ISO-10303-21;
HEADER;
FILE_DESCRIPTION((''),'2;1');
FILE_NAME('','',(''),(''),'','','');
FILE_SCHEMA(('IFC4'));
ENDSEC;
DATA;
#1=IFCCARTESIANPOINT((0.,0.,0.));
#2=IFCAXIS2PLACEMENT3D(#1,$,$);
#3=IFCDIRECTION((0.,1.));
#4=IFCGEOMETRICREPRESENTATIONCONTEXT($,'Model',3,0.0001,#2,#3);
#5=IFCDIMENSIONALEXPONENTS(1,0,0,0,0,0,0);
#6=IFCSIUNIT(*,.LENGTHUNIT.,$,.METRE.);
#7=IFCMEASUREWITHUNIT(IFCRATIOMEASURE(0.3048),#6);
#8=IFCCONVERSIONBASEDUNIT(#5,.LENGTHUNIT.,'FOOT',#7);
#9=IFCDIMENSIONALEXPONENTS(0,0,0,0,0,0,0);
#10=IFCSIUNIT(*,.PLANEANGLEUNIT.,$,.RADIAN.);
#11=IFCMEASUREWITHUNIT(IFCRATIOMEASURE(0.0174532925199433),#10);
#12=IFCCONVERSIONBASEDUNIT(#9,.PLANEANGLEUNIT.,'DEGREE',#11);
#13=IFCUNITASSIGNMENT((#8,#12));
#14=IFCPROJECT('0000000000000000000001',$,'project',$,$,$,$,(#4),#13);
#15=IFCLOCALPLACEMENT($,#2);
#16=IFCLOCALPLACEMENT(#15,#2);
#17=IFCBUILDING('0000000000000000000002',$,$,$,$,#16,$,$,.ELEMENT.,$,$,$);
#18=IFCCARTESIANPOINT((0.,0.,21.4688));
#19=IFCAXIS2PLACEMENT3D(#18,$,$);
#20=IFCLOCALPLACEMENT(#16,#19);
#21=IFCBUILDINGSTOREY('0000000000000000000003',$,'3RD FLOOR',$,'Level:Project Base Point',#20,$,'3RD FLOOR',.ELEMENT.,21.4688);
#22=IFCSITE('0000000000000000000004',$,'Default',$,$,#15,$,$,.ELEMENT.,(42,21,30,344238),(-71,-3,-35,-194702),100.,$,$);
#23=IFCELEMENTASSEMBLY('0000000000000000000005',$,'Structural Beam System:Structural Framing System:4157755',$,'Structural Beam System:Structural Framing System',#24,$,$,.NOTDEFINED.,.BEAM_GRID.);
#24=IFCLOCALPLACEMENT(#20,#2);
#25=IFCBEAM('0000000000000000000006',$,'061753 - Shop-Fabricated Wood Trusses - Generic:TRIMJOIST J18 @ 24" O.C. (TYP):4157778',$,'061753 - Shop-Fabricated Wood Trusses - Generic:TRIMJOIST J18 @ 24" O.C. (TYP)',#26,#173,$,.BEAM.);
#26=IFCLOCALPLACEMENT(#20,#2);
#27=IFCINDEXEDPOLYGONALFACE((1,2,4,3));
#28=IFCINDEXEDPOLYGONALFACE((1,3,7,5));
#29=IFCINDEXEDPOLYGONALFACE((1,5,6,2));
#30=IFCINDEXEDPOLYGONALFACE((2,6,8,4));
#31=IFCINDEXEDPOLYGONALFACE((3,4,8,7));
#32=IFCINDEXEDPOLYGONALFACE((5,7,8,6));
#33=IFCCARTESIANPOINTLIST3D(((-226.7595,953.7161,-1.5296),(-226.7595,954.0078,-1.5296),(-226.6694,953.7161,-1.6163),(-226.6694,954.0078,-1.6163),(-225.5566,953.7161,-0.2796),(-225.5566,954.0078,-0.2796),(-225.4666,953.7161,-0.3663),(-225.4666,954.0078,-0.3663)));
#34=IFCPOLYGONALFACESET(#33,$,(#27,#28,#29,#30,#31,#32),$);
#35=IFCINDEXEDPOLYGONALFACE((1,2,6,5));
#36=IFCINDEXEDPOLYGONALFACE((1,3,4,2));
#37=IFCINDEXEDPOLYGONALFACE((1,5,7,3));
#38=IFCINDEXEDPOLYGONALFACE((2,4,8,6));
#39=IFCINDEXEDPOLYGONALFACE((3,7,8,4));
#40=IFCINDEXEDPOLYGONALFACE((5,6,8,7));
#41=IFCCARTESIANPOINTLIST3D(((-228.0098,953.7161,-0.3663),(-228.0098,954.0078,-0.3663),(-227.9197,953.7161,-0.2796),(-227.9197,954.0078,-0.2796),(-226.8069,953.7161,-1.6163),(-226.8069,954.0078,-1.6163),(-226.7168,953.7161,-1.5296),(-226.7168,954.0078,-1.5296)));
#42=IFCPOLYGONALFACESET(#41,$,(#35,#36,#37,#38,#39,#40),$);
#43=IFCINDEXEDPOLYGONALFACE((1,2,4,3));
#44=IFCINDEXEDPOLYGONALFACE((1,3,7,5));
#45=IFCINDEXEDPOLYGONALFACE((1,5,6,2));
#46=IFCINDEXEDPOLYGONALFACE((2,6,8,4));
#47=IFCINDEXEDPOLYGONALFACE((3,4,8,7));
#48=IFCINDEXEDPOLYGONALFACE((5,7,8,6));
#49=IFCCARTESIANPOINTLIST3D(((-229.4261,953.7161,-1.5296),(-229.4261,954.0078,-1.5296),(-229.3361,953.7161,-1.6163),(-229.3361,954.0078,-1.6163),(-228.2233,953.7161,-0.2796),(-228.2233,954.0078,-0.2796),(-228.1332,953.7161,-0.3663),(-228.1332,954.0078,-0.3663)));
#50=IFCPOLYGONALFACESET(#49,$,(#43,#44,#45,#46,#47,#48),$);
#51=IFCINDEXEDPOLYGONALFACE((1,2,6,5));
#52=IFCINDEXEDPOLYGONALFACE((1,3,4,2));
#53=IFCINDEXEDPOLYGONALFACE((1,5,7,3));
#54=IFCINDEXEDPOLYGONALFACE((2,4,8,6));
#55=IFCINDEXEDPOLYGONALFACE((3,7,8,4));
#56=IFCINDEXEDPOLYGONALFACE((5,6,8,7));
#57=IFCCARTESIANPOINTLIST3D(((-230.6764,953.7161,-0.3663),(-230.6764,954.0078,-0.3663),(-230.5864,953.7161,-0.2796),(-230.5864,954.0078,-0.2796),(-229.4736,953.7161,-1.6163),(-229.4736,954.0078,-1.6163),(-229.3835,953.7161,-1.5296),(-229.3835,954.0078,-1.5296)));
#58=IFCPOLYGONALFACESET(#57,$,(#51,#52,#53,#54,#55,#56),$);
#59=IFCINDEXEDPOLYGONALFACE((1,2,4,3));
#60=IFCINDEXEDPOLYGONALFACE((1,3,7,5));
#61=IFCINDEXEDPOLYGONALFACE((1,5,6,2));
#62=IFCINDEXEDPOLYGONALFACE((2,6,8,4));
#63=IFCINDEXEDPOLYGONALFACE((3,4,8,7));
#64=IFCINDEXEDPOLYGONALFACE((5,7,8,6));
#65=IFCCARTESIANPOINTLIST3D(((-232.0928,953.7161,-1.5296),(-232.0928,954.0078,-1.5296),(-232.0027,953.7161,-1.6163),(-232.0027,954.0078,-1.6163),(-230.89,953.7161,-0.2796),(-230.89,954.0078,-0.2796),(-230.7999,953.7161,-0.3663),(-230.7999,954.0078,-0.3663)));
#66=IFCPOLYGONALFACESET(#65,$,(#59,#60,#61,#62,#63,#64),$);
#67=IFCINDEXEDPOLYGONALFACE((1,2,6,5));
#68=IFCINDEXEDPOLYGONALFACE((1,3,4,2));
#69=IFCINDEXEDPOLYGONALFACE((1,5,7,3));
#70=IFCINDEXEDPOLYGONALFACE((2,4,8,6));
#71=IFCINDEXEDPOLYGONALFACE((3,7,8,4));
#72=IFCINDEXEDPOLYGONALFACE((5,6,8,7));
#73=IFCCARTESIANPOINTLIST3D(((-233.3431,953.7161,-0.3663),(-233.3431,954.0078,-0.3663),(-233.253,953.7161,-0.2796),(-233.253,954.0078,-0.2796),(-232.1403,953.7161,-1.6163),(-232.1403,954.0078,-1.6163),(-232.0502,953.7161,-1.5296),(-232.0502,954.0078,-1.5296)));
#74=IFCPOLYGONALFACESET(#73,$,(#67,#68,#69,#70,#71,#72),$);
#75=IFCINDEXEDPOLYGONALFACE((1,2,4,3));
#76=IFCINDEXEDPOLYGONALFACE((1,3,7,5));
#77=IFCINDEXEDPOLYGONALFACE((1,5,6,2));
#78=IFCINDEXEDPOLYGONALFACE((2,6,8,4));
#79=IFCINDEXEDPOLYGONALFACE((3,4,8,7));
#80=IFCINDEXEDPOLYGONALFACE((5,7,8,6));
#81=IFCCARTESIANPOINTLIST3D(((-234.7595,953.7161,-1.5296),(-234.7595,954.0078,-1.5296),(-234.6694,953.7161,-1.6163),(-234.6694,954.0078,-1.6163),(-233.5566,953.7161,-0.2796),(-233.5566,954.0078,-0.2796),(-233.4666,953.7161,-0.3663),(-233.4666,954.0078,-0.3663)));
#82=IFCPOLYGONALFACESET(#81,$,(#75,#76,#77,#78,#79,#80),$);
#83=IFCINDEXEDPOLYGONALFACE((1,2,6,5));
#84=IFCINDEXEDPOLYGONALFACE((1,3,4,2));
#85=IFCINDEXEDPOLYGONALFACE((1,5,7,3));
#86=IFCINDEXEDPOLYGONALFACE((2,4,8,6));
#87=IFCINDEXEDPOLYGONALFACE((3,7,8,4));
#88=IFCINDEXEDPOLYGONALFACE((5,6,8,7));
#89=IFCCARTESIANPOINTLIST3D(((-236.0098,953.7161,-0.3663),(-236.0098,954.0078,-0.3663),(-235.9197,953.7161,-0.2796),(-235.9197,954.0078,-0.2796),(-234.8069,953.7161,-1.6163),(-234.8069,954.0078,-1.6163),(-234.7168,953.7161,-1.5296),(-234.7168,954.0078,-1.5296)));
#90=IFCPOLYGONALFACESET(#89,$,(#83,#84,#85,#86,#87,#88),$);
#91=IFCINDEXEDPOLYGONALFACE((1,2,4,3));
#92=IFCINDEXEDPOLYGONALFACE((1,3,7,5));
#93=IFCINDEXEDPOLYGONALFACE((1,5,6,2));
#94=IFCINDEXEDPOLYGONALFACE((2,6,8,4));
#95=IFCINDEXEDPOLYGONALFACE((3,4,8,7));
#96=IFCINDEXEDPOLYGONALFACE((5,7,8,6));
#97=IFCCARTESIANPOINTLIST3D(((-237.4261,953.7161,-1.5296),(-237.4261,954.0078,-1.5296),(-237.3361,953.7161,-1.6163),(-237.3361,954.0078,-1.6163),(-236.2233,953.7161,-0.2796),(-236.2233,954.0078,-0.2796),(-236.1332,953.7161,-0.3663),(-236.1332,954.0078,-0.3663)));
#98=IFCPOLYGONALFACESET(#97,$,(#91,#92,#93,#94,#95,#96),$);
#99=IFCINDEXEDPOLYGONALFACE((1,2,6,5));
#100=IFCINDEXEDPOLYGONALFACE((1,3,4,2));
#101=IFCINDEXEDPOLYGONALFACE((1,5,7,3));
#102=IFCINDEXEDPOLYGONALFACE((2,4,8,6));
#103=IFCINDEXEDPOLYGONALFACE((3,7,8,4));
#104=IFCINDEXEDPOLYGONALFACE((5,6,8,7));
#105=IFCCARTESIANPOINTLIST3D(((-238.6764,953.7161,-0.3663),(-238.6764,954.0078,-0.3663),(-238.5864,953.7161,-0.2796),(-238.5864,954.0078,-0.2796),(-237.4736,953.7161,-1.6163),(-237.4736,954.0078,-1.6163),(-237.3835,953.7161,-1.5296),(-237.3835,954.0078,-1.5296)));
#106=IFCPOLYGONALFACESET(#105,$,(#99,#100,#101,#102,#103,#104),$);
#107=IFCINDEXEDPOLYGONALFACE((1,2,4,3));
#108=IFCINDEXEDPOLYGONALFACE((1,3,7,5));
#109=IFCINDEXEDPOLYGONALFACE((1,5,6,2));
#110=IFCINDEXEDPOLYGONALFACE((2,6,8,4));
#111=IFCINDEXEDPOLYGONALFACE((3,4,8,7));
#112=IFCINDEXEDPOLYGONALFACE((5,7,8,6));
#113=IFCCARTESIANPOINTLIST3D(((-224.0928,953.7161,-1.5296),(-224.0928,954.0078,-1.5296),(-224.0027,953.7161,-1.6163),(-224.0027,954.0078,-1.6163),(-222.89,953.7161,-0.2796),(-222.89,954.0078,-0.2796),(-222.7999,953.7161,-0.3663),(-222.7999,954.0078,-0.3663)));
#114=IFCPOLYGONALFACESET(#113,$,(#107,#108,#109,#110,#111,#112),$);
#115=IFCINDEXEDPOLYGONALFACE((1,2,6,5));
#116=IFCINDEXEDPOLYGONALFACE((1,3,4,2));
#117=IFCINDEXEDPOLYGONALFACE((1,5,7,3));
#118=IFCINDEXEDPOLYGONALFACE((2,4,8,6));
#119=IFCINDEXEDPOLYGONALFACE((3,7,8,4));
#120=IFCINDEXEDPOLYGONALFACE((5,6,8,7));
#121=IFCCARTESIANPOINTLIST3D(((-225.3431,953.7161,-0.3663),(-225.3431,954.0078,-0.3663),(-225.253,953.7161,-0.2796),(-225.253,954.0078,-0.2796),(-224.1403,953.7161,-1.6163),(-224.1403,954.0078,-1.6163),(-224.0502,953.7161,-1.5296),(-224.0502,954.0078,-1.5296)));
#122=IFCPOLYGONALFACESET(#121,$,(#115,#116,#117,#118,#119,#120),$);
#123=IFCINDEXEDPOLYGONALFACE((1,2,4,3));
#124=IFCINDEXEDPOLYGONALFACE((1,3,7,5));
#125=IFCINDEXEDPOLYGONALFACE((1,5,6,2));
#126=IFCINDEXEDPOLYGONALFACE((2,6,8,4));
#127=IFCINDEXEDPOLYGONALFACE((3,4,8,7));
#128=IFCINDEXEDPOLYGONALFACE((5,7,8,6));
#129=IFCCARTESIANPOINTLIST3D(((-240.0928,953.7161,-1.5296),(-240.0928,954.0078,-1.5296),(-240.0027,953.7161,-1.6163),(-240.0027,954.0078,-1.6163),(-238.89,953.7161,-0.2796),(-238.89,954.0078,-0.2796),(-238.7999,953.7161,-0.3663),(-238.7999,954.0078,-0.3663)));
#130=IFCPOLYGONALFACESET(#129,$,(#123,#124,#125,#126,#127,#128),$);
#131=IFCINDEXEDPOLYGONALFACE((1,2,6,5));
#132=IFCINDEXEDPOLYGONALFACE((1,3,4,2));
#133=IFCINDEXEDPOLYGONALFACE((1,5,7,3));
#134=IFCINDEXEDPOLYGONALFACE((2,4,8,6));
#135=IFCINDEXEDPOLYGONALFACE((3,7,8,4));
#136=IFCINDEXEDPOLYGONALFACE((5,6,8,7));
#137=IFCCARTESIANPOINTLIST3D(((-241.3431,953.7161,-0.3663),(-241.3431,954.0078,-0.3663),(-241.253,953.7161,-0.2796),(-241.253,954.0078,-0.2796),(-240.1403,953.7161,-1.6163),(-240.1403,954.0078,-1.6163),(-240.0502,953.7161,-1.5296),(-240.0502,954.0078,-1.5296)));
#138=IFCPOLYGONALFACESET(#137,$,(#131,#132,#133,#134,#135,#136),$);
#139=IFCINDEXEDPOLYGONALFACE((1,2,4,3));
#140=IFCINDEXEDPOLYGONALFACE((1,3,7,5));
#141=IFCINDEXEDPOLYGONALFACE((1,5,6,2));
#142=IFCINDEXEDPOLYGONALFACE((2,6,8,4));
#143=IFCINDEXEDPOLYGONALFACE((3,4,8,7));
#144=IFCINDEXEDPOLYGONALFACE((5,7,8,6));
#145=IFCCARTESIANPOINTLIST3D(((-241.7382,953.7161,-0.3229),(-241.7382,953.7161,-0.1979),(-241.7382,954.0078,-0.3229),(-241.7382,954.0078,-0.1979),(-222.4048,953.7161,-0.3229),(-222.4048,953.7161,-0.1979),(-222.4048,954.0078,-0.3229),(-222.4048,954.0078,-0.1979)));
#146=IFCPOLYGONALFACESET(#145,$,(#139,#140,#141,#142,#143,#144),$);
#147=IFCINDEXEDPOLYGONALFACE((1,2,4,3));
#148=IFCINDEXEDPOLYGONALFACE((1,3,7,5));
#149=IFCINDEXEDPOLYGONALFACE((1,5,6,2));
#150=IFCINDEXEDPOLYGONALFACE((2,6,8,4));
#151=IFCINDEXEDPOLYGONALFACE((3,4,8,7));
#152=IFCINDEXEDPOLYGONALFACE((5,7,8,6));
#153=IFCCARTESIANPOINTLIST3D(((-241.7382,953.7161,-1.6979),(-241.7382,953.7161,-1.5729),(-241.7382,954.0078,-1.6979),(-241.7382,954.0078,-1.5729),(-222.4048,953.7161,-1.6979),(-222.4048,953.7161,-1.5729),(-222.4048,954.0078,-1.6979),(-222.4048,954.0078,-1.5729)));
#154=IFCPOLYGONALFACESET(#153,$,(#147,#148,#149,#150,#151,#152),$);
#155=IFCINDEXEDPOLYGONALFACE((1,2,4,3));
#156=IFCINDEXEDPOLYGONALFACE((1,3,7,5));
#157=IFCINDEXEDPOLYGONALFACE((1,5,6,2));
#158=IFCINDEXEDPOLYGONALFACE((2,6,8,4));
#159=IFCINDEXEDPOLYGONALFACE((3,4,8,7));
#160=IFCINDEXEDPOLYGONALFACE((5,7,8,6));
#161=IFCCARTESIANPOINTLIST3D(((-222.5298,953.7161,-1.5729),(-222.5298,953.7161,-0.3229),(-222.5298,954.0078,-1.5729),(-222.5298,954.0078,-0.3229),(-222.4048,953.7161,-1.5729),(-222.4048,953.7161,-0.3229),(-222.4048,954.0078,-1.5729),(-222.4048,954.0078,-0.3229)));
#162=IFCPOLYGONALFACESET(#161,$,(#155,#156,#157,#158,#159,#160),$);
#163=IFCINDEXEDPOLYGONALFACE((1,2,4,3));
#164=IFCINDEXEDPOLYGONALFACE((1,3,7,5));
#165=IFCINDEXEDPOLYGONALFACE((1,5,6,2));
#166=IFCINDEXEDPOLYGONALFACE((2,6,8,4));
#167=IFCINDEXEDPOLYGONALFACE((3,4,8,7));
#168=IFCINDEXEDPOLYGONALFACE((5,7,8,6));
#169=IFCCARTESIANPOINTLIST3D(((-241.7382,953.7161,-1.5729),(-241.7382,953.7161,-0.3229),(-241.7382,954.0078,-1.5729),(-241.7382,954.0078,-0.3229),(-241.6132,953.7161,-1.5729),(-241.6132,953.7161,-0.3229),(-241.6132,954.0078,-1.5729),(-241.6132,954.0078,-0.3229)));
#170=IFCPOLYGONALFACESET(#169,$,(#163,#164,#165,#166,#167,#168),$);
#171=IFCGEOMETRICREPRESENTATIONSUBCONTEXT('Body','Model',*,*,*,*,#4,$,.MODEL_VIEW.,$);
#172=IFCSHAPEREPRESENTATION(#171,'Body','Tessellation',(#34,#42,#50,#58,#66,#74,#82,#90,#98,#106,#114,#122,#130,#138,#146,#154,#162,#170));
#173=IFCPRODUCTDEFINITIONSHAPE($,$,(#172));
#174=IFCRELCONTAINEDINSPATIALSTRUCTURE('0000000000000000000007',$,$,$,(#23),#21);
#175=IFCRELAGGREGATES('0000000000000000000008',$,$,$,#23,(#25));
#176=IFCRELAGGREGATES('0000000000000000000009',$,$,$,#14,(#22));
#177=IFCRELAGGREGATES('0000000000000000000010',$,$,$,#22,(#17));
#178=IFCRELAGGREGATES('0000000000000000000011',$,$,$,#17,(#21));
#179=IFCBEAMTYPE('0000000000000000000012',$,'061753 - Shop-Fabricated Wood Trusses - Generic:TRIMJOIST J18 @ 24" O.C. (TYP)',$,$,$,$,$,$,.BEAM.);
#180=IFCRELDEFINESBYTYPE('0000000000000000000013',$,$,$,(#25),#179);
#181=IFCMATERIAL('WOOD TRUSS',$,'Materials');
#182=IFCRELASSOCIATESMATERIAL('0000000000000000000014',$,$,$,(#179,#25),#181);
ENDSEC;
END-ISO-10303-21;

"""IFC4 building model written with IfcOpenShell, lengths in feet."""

from ifc_helpers import new_model, entity, si_unit, converted_unit, direction, frame, frame_2d, origin, origin_2d_with_axis, place, context, subcontext, project, spatial, rectangle, extrude, source, transform, mapped, material, material_profile, profile_set, profile_usage, type_object, type_shapes, element, aggregate, save


model = new_model("IFC4")

# Units and contexts
model_context = context("Model", 3, precision=0.0001, world=origin(), true_north=direction((0.0, 1.0)))
body_context = subcontext(model_context, "Body", "Model", "MODEL_VIEW")
ifc_project = project(units=[converted_unit("LENGTHUNIT", "FOOT", entity("IfcRatioMeasure", 0.3048), si_unit("LENGTHUNIT", "METRE"), dimensions=[1, 0, 0, 0, 0, 0, 0]), converted_unit("PLANEANGLEUNIT", "DEGREE", entity("IfcRatioMeasure", 0.0174532925199433), si_unit("PLANEANGLEUNIT", "RADIAN"), dimensions=[0, 0, 0, 0, 0, 0, 0])], contexts=[model_context])

# Site, building, storey
site_placement = place(None, origin())
site = spatial("IfcSite", under=ifc_project, at=site_placement, Name="Default", CompositionType="ELEMENT", RefLatitude=(42, 21, 30, 344238), RefLongitude=(-71, -3, -35, -194702), RefElevation=100.0)
building_placement = place(site_placement, origin())
building = spatial("IfcBuilding", under=site, at=building_placement, CompositionType="ELEMENT")
storey_placement = place(building_placement, frame((0.0, 0.0, 21.4688)))
storey = spatial("IfcBuildingStorey", under=building, at=storey_placement, Name="3RD FLOOR", ObjectType="Level:Project Base Point", LongName="3RD FLOOR", CompositionType="ELEMENT", Elevation=21.4688)

# Element assembly, beam
assembly_1_placement = place(storey_placement, origin())
assembly_1 = element("IfcElementAssembly", 1, at=assembly_1_placement, inside=storey, Name="Structural Beam System:Structural Framing System:4157755", ObjectType="Structural Beam System:Structural Framing System", AssemblyPlace="NOTDEFINED", PredefinedType="BEAM_GRID")
ifc_material_1 = material(Name="WOOD TRUSS", Category="Materials")
ifc_material_profile_1 = material_profile(ifc_material_1, rectangle(XDim=1.7347, YDim=0.125, at=frame_2d((0.0, 0.0), x_axis=(1.0, 0.0))), Name="TRIMJOIST J18 @ 24\" O.C. (TYP)")
ifc_material_profile_2 = material_profile(ifc_material_1, rectangle(XDim=1.7347, YDim=0.125, at=frame_2d((0.0, 0.0), x_axis=(1.0, 0.0))), Name="TRIMJOIST J18 @ 24\" O.C. (TYP)")
ifc_material_profile_3 = material_profile(ifc_material_1, rectangle(XDim=1.7347, YDim=0.125, at=frame_2d((0.0, 0.0), x_axis=(1.0, 0.0))), Name="TRIMJOIST J18 @ 24\" O.C. (TYP)")
ifc_material_profile_4 = material_profile(ifc_material_1, rectangle(XDim=1.7347, YDim=0.125, at=frame_2d((0.0, 0.0), x_axis=(1.0, 0.0))), Name="TRIMJOIST J18 @ 24\" O.C. (TYP)")
ifc_material_profile_5 = material_profile(ifc_material_1, rectangle(XDim=1.7347, YDim=0.125, at=frame_2d((0.0, 0.0), x_axis=(1.0, 0.0))), Name="TRIMJOIST J18 @ 24\" O.C. (TYP)")
ifc_material_profile_6 = material_profile(ifc_material_1, rectangle(XDim=1.7347, YDim=0.125, at=frame_2d((0.0, 0.0), x_axis=(1.0, 0.0))), Name="TRIMJOIST J18 @ 24\" O.C. (TYP)")
ifc_material_profile_7 = material_profile(ifc_material_1, rectangle(XDim=1.7347, YDim=0.125, at=frame_2d((0.0, 0.0), x_axis=(1.0, 0.0))), Name="TRIMJOIST J18 @ 24\" O.C. (TYP)")
ifc_material_profile_8 = material_profile(ifc_material_1, rectangle(XDim=1.7347, YDim=0.125, at=frame_2d((0.0, 0.0), x_axis=(1.0, 0.0))), Name="TRIMJOIST J18 @ 24\" O.C. (TYP)")
ifc_material_profile_9 = material_profile(ifc_material_1, rectangle(XDim=1.7347, YDim=0.125, at=frame_2d((0.0, 0.0), x_axis=(1.0, 0.0))), Name="TRIMJOIST J18 @ 24\" O.C. (TYP)")
ifc_material_profile_10 = material_profile(ifc_material_1, rectangle(XDim=1.7347, YDim=0.125, at=origin_2d_with_axis()), Name="TRIMJOIST J18 @ 24\" O.C. (TYP)")
ifc_material_profile_11 = material_profile(ifc_material_1, rectangle(XDim=0.125, YDim=0.2917, at=origin_2d_with_axis()), Name="TRIMJOIST J18 @ 24\" O.C. (TYP)")
ifc_material_profile_12 = material_profile(ifc_material_1, rectangle(XDim=0.125, YDim=0.2917, at=origin_2d_with_axis()), Name="TRIMJOIST J18 @ 24\" O.C. (TYP)")
ifc_material_profile_13 = material_profile(ifc_material_1, rectangle(XDim=1.25, YDim=0.2917, at=origin_2d_with_axis()), Name="TRIMJOIST J18 @ 24\" O.C. (TYP)")
ifc_material_profile_14 = material_profile(ifc_material_1, rectangle(XDim=1.25, YDim=0.2917, at=origin_2d_with_axis()), Name="TRIMJOIST J18 @ 24\" O.C. (TYP)")
ifc_profile_set_1 = profile_set([ifc_material_profile_1, ifc_material_profile_2, ifc_material_profile_3, ifc_material_profile_4, ifc_material_profile_5, ifc_material_profile_6, ifc_material_profile_7, ifc_material_profile_8, ifc_material_profile_9, ifc_material_profile_10, ifc_material_profile_11, ifc_material_profile_12, ifc_material_profile_13, ifc_material_profile_14], Name="TRIMJOIST J18 @ 24\" O.C. (TYP)")
ifc_profile_usage_1 = profile_usage(ifc_profile_set_1, cardinal=8)
beam_type_1 = type_object("IfcBeamType", Name="061753 - Shop-Fabricated Wood Trusses - Generic:TRIMJOIST J18 @ 24\" O.C. (TYP)", PredefinedType="BEAM", material=ifc_profile_set_1)
shared_shape_1 = source(origin(), body_context, "Body", "SweptSolid", [
    extrude(rectangle(XDim=1.7347, YDim=0.125, at=frame_2d((0.0, 0.0), x_axis=(1.0, 0.0))), frame((5.9585, -0.1458, 0.0), z_axis=(0.0, 1.0, 0.0), x_axis=(0.693383, 0.0, 0.720569)), (0.0, 0.0, 1.0), 0.2917),
    extrude(rectangle(XDim=1.7347, YDim=0.125, at=origin_2d_with_axis()), frame((4.7082, -0.1458, 0.0), z_axis=(0.0, 1.0, 0.0), x_axis=(0.693383, 0.0, -0.720569)), (0.0, 0.0, 1.0), 0.2917),
    extrude(rectangle(XDim=1.7347, YDim=0.125, at=frame_2d((0.0, 0.0), x_axis=(1.0, 0.0))), frame((3.2918, -0.1458, 0.0), z_axis=(0.0, 1.0, 0.0), x_axis=(0.693383, 0.0, 0.720569)), (0.0, 0.0, 1.0), 0.2917),
    extrude(rectangle(XDim=1.7347, YDim=0.125, at=frame_2d((0.0, 0.0), x_axis=(1.0, 0.0))), frame((2.0415, -0.1458, 0.0), z_axis=(0.0, 1.0, 0.0), x_axis=(0.693383, 0.0, -0.720569)), (0.0, 0.0, 1.0), 0.2917),
    extrude(rectangle(XDim=1.7347, YDim=0.125, at=frame_2d((0.0, 0.0), x_axis=(1.0, 0.0))), frame((0.6251, -0.1458, 0.0), z_axis=(0.0, 1.0, 0.0), x_axis=(0.693383, 0.0, 0.720569)), (0.0, 0.0, 1.0), 0.2917),
    extrude(rectangle(XDim=1.7347, YDim=0.125, at=frame_2d((0.0, 0.0), x_axis=(1.0, 0.0))), frame((-0.6251, -0.1458, 0.0), z_axis=(0.0, 1.0, 0.0), x_axis=(0.693383, 0.0, -0.720569)), (0.0, 0.0, 1.0), 0.2917),
    extrude(rectangle(XDim=1.7347, YDim=0.125, at=frame_2d((0.0, 0.0), x_axis=(1.0, 0.0))), frame((-2.0415, -0.1458, 0.0), z_axis=(0.0, 1.0, 0.0), x_axis=(0.693383, 0.0, 0.720569)), (0.0, 0.0, 1.0), 0.2917),
    extrude(rectangle(XDim=1.7347, YDim=0.125, at=origin_2d_with_axis()), frame((-3.2918, -0.1458, 0.0), z_axis=(0.0, 1.0, 0.0), x_axis=(0.693383, 0.0, -0.720569)), (0.0, 0.0, 1.0), 0.2917),
    extrude(rectangle(XDim=1.7347, YDim=0.125, at=frame_2d((0.0, 0.0), x_axis=(1.0, 0.0))), frame((-4.7082, -0.1458, 0.0), z_axis=(0.0, 1.0, 0.0), x_axis=(0.693383, 0.0, 0.720569)), (0.0, 0.0, 1.0), 0.2917),
    extrude(rectangle(XDim=1.7347, YDim=0.125, at=frame_2d((0.0, 0.0), x_axis=(1.0, 0.0))), frame((-5.9585, -0.1458, 0.0), z_axis=(0.0, 1.0, 0.0), x_axis=(0.693383, 0.0, -0.720569)), (0.0, 0.0, 1.0), 0.2917),
    extrude(rectangle(XDim=1.7347, YDim=0.125, at=frame_2d((0.0, 0.0), x_axis=(1.0, 0.0))), frame((8.6251, -0.1458, 0.0), z_axis=(0.0, 1.0, 0.0), x_axis=(0.693383, 0.0, 0.720569)), (0.0, 0.0, 1.0), 0.2917),
    extrude(rectangle(XDim=1.7347, YDim=0.125, at=origin_2d_with_axis()), frame((7.3749, -0.1458, 0.0), z_axis=(0.0, 1.0, 0.0), x_axis=(0.693383, 0.0, -0.720569)), (0.0, 0.0, 1.0), 0.2917),
    extrude(rectangle(XDim=1.7347, YDim=0.125, at=frame_2d((0.0, 0.0), x_axis=(1.0, 0.0))), frame((-7.3749, -0.1458, 0.0), z_axis=(0.0, 1.0, 0.0), x_axis=(0.693383, 0.0, 0.720569)), (0.0, 0.0, 1.0), 0.2917),
    extrude(rectangle(XDim=1.7347, YDim=0.125, at=origin_2d_with_axis()), frame((-8.6251, -0.1458, 0.0), z_axis=(0.0, 1.0, 0.0), x_axis=(0.693383, 0.0, -0.720569)), (0.0, 0.0, 1.0), 0.2917),
    extrude(rectangle(XDim=0.125, YDim=0.2917, at=origin_2d_with_axis()), frame((-9.6667, 0.0, 0.6875), z_axis=(1.0, 0.0, 0.0), x_axis=(0.0, 0.0, -1.0)), (0.0, 0.0, 1.0), 19.3333),
    extrude(rectangle(XDim=0.125, YDim=0.2917, at=origin_2d_with_axis()), frame((-9.6667, 0.0, -0.6875), z_axis=(1.0, 0.0, 0.0), x_axis=(0.0, 0.0, -1.0)), (0.0, 0.0, 1.0), 19.3333),
    extrude(rectangle(XDim=1.25, YDim=0.2917, at=origin_2d_with_axis()), frame((9.5417, 0.0, 0.0), z_axis=(1.0, 0.0, 0.0), x_axis=(0.0, 0.0, -1.0)), (0.0, 0.0, 1.0), 0.125),
    extrude(rectangle(XDim=1.25, YDim=0.2917, at=origin_2d_with_axis()), frame((-9.6667, 0.0, 0.0), z_axis=(1.0, 0.0, 0.0), x_axis=(0.0, 0.0, -1.0)), (0.0, 0.0, 1.0), 0.125),
])
type_shapes(beam_type_1, [shared_shape_1])
beam_1_placement = place(assembly_1_placement, frame((-232.0715, 953.8619, -0.9479)))
beam_1 = element("IfcBeam", 2, at=beam_1_placement, type_object=beam_type_1, material=ifc_profile_usage_1, Name="061753 - Shop-Fabricated Wood Trusses - Generic:TRIMJOIST J18 @ 24\" O.C. (TYP):4157778", ObjectType="061753 - Shop-Fabricated Wood Trusses - Generic:TRIMJOIST J18 @ 24\" O.C. (TYP)", PredefinedType="BEAM", context=body_context, shape_type="MappedRepresentation", body=[
    mapped(shared_shape_1, transform((0.0, 0.0, 0.0), scale=1.0)),
])
aggregate(assembly_1, [beam_1])

save(model, "model.ifc")
